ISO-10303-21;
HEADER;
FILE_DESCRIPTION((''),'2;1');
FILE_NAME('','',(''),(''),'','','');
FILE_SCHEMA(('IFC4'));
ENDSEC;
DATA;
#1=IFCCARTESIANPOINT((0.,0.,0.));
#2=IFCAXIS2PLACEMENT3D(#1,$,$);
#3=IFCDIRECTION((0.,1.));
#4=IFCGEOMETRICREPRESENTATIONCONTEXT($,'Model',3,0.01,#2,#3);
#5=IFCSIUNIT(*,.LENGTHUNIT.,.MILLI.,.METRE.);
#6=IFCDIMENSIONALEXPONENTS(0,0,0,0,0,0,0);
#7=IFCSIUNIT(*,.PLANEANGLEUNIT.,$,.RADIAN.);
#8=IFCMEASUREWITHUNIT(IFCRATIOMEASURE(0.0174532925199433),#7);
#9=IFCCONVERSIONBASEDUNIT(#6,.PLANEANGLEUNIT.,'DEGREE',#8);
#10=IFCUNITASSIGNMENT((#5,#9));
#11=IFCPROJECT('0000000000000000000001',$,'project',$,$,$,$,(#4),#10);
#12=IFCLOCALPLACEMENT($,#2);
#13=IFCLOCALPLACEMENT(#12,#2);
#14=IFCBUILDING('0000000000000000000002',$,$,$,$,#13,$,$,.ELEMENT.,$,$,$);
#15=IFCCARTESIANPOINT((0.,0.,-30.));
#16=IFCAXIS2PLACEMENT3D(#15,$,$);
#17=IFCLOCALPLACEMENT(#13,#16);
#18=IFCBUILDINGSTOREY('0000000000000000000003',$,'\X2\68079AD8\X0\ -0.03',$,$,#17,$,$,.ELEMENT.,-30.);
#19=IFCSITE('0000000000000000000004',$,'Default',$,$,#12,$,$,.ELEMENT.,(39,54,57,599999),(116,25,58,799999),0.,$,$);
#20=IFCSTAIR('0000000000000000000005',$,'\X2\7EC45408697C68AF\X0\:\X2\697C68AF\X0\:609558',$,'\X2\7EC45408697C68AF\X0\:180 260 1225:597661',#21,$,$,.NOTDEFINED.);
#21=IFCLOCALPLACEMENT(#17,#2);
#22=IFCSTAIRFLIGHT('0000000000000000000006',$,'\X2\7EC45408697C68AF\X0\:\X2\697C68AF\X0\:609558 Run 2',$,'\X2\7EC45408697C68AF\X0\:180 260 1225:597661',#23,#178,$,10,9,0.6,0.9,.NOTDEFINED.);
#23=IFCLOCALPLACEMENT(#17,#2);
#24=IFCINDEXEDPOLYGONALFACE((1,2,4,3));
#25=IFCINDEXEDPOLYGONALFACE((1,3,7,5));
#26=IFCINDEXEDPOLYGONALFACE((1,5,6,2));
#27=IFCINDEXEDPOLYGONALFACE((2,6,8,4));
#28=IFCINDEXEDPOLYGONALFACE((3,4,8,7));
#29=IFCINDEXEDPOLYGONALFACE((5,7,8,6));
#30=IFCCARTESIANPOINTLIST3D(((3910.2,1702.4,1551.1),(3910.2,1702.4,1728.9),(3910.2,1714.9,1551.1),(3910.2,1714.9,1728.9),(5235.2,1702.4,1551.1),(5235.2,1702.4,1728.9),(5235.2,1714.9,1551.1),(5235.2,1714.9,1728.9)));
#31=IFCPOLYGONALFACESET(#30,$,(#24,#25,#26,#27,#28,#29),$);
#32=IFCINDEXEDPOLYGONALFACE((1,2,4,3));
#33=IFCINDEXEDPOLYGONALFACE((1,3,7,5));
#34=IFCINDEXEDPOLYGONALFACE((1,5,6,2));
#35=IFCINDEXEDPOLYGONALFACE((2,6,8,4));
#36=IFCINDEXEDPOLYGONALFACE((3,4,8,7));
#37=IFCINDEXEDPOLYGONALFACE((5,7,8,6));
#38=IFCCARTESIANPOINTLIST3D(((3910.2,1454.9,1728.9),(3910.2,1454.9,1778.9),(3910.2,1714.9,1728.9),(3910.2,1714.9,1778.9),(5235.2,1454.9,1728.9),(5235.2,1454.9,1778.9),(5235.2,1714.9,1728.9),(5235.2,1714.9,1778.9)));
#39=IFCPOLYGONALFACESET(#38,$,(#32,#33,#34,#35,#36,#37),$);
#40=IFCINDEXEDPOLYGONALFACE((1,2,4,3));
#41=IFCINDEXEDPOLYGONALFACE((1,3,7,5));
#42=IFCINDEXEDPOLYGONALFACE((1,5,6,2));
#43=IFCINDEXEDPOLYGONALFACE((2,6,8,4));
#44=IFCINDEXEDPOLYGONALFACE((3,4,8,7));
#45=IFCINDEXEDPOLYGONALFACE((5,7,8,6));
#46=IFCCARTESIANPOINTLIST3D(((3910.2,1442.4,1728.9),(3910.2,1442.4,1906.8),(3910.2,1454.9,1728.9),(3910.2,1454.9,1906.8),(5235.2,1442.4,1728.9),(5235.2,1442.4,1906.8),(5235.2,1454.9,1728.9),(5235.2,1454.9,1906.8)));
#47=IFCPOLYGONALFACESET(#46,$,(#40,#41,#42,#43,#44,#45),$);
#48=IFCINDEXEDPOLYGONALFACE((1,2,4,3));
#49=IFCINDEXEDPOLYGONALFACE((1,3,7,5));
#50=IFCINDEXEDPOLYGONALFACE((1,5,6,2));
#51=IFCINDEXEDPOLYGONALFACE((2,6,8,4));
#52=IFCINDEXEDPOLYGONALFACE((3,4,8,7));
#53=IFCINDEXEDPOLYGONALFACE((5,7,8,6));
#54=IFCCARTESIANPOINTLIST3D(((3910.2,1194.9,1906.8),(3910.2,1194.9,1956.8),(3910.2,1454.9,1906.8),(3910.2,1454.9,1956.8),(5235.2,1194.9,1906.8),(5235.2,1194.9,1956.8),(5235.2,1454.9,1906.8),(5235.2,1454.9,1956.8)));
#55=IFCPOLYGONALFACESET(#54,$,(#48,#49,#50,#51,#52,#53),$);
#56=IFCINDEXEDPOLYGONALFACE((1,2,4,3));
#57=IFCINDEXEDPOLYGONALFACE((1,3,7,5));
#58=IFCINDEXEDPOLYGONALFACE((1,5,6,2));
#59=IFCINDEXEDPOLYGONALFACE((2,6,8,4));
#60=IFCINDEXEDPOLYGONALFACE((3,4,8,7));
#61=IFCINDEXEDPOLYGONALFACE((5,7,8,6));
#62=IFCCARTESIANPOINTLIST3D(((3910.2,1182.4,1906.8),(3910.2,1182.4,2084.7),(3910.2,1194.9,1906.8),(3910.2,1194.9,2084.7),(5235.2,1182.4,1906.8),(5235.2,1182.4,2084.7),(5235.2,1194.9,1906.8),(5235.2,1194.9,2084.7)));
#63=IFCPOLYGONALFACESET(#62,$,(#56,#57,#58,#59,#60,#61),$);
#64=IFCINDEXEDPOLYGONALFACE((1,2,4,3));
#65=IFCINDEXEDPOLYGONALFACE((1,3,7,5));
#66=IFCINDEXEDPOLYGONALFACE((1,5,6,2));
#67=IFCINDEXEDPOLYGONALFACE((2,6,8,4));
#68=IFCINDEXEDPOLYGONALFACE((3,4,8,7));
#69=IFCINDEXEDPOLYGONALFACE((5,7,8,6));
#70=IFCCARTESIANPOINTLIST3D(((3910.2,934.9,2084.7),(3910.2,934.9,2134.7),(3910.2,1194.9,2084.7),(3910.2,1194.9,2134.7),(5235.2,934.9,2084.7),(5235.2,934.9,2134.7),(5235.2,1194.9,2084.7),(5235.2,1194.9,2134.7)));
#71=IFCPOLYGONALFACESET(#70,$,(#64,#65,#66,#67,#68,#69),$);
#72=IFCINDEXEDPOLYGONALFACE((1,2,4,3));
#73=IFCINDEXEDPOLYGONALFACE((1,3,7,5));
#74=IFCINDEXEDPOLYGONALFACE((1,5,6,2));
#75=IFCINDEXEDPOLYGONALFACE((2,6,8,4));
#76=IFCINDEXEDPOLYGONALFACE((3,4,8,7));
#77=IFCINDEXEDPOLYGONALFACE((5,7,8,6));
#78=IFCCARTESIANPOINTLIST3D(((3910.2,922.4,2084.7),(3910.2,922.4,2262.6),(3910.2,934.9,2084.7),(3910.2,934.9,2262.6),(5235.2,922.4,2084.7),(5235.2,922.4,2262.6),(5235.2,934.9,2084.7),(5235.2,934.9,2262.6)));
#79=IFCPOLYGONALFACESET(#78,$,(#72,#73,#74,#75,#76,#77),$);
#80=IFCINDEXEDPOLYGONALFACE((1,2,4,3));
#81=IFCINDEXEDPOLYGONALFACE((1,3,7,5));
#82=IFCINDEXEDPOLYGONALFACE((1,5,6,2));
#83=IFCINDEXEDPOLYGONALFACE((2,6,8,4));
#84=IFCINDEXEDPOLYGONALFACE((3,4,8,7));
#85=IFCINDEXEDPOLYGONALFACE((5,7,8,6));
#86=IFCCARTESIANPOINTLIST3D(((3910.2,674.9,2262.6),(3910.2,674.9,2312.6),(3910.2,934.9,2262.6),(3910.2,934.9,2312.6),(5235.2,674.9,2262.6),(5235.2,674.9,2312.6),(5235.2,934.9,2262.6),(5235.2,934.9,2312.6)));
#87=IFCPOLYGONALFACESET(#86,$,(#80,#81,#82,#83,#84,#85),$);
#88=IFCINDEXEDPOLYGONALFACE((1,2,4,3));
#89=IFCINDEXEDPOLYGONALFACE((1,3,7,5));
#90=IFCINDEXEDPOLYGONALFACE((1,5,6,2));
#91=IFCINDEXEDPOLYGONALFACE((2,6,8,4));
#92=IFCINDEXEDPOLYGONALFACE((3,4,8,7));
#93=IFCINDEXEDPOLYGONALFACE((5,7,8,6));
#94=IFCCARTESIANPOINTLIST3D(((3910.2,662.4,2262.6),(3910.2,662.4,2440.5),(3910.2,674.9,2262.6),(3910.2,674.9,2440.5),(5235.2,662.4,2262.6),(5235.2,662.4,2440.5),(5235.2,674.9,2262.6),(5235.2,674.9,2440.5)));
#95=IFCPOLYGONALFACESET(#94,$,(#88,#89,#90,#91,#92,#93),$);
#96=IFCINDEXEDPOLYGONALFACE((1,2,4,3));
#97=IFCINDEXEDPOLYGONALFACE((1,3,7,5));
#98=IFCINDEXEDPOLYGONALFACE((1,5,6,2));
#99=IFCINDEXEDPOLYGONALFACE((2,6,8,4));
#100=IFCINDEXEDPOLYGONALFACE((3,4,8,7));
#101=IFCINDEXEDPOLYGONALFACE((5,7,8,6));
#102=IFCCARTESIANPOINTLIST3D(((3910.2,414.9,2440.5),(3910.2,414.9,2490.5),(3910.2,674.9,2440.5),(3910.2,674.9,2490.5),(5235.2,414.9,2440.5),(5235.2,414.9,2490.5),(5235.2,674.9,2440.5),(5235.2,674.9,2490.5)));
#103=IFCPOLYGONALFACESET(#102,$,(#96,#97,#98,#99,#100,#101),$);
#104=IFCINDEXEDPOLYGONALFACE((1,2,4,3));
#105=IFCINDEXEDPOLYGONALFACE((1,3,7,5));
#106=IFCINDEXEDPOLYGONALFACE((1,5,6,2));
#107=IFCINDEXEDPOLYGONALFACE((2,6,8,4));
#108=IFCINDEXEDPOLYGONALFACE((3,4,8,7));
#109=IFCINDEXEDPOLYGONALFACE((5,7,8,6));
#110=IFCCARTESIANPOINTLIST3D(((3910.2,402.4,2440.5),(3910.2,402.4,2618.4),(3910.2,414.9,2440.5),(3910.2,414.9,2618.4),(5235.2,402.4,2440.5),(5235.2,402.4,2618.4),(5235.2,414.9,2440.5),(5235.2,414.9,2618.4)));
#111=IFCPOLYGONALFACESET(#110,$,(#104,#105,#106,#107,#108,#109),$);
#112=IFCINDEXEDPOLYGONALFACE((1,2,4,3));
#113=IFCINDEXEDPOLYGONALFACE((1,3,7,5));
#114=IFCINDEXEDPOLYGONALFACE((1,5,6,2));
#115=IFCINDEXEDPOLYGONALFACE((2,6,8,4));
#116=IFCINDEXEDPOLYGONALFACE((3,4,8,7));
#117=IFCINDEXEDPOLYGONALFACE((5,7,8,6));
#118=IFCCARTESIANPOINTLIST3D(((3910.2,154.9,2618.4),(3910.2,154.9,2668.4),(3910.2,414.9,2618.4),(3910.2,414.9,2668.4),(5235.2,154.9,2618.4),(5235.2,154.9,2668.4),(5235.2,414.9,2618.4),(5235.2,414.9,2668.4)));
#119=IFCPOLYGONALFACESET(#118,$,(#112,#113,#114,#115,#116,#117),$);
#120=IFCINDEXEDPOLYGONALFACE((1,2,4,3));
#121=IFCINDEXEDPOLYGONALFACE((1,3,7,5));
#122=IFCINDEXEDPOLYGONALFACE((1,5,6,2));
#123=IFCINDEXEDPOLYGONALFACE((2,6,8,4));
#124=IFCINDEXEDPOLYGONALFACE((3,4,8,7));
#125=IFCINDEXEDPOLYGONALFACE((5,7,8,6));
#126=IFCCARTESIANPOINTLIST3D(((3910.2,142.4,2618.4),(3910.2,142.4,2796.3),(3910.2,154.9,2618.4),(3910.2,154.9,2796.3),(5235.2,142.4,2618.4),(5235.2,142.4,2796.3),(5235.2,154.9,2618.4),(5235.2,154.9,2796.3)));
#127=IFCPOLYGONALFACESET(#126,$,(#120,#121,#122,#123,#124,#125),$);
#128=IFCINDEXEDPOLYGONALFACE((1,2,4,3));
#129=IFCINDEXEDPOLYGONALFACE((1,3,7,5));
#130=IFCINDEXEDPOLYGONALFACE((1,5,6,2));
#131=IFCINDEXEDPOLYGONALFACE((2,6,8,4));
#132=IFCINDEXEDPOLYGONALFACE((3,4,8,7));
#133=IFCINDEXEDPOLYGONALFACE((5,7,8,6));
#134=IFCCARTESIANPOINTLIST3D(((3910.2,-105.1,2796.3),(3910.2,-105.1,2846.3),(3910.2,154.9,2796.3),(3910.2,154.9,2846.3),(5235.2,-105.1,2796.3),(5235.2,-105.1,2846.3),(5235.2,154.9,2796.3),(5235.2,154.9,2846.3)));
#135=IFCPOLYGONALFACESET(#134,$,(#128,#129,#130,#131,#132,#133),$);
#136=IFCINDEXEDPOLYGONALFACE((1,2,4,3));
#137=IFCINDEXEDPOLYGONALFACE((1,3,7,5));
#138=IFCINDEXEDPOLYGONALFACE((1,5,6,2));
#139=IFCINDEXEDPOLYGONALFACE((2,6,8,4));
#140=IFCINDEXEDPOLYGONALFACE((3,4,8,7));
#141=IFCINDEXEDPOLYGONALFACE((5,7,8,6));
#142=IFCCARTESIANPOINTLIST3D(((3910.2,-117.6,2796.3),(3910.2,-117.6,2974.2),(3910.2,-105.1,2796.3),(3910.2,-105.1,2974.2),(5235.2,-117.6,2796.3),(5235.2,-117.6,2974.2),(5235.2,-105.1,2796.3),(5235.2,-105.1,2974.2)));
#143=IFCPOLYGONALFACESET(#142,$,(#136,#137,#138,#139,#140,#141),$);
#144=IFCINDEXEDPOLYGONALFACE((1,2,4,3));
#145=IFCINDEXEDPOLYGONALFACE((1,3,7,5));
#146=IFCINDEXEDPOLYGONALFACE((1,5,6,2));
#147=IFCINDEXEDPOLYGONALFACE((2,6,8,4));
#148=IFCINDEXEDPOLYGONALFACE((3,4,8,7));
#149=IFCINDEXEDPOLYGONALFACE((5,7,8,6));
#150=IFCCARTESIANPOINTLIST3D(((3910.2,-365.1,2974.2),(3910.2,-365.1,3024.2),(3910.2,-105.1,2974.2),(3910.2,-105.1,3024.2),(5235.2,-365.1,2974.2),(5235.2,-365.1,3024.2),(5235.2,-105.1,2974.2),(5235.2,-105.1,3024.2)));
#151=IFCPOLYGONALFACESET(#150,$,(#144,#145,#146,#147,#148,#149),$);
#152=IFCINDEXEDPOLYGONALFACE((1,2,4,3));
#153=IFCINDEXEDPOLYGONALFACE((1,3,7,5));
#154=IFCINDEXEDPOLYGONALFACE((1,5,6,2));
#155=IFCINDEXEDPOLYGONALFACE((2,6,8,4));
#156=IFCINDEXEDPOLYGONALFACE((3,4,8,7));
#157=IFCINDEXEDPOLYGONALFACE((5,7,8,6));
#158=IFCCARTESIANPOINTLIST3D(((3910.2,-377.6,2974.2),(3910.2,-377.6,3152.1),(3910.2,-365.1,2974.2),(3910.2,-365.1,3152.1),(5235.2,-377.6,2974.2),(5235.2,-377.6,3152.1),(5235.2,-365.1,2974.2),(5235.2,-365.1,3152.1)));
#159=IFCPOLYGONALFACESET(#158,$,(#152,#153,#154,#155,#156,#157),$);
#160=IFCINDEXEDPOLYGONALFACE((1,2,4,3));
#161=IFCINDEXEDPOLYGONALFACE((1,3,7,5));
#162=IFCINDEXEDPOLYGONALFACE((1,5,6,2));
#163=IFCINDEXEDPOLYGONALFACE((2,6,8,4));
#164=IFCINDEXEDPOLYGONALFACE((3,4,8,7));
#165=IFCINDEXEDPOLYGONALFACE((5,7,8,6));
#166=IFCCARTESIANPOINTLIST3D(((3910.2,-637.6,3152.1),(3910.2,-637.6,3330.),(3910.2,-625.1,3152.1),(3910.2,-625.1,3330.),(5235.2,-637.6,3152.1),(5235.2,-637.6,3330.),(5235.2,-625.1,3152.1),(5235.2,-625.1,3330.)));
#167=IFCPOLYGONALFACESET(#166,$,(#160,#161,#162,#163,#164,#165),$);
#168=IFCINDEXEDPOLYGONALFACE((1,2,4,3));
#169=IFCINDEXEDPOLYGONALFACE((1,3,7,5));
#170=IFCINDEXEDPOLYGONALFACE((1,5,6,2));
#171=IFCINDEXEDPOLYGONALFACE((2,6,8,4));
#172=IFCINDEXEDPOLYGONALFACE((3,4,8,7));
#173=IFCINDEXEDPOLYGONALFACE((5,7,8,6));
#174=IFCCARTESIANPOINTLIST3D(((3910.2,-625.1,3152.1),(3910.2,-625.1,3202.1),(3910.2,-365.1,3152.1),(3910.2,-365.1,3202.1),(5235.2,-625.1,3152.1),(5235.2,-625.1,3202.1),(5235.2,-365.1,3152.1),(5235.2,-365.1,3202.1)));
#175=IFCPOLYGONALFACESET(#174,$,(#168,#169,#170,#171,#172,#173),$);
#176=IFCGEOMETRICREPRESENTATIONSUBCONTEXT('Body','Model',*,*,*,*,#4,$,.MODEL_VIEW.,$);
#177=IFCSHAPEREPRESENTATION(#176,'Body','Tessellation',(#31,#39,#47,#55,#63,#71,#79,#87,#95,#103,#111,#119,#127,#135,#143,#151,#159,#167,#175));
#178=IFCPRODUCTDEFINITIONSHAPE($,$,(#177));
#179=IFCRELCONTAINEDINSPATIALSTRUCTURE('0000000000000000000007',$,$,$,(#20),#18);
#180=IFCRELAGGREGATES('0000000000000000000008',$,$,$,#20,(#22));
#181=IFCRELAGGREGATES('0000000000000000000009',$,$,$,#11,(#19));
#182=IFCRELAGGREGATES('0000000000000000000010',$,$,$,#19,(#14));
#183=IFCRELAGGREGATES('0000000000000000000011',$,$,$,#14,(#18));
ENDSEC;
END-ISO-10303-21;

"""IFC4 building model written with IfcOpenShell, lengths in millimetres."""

from ifc_helpers import new_model, entity, si_unit, converted_unit, direction, frame, frame_2d, origin, origin_2d_with_axis, place, context, subcontext, project, spatial, rectangle, extrude, element, aggregate, save


model = new_model("IFC4")

# Units and contexts
model_context = context("Model", 3, precision=0.01, world=origin(), true_north=direction((0.0, 1.0)))
body_context = subcontext(model_context, "Body", "Model", "MODEL_VIEW")
ifc_project = project(units=[si_unit("LENGTHUNIT", "METRE", prefix="MILLI"), converted_unit("PLANEANGLEUNIT", "DEGREE", entity("IfcRatioMeasure", 0.0174532925199433), si_unit("PLANEANGLEUNIT", "RADIAN"), dimensions=[0, 0, 0, 0, 0, 0, 0])], contexts=[model_context])

# Site, building, storey
site_placement = place(None, origin())
site = spatial("IfcSite", under=ifc_project, at=site_placement, Name="Default", CompositionType="ELEMENT", RefLatitude=(39, 54, 57, 599999), RefLongitude=(116, 25, 58, 799999), RefElevation=0.0)
building_placement = place(site_placement, origin())
building = spatial("IfcBuilding", under=site, at=building_placement, CompositionType="ELEMENT")
storey_placement = place(building_placement, frame((0.0, 0.0, -30.0)))
storey = spatial("IfcBuildingStorey", under=building, at=storey_placement, Name="标高 -0.03", CompositionType="ELEMENT", Elevation=-30.0)

# Stair, stair flight
stair_placement = place(storey_placement, origin())
stair = element("IfcStair", 1, at=stair_placement, inside=storey, Name="组合楼梯:楼梯:609558", ObjectType="组合楼梯:180 260 1225:597661", PredefinedType="NOTDEFINED")
stair_flight_1_placement = place(stair_placement, frame((3910.2, -637.6, 0.0)))
stair_flight_1 = element("IfcStairFlight", 2, at=stair_flight_1_placement, Name="组合楼梯:楼梯:609558 Run 2", ObjectType="组合楼梯:180 260 1225:597661", NumberOfRisers=10, NumberOfTreads=9, PredefinedType="NOTDEFINED", RiserHeight=0.6, TreadLength=0.9, context=body_context, shape_type="SweptSolid", body=[
    extrude(rectangle(XDim=1325.0, YDim=12.5, at=frame_2d((0.0, 0.0), x_axis=(1.0, 0.0))), frame((662.5, 2346.2, 1551.1)), (0.0, 0.0, 1.0), 177.9),
    extrude(rectangle(XDim=260.0, YDim=1325.0, at=frame_2d((0.0, 0.0), x_axis=(1.0, 0.0))), frame((662.5, 2222.5, 1728.9), z_axis=(0.0, 0.0, 1.0), x_axis=(0.0, 1.0, 0.0)), (0.0, 0.0, 1.0), 50.0),
    extrude(rectangle(XDim=1325.0, YDim=12.5, at=origin_2d_with_axis()), frame((662.5, 2086.2, 1728.9)), (0.0, 0.0, 1.0), 177.9),
    extrude(rectangle(XDim=260.0, YDim=1325.0, at=frame_2d((0.0, 0.0), x_axis=(1.0, 0.0))), frame((662.5, 1962.5, 1906.8), z_axis=(0.0, 0.0, 1.0), x_axis=(0.0, 1.0, 0.0)), (0.0, 0.0, 1.0), 50.0),
    extrude(rectangle(XDim=1325.0, YDim=12.5, at=origin_2d_with_axis()), frame((662.5, 1826.2, 1906.8)), (0.0, 0.0, 1.0), 177.9),
    extrude(rectangle(XDim=260.0, YDim=1325.0, at=frame_2d((0.0, 0.0), x_axis=(1.0, 0.0))), frame((662.5, 1702.5, 2084.7), z_axis=(0.0, 0.0, 1.0), x_axis=(0.0, 1.0, 0.0)), (0.0, 0.0, 1.0), 50.0),
    extrude(rectangle(XDim=1325.0, YDim=12.5, at=origin_2d_with_axis()), frame((662.5, 1566.2, 2084.7)), (0.0, 0.0, 1.0), 177.9),
    extrude(rectangle(XDim=260.0, YDim=1325.0, at=frame_2d((0.0, 0.0), x_axis=(1.0, 0.0))), frame((662.5, 1442.5, 2262.6), z_axis=(0.0, 0.0, 1.0), x_axis=(0.0, 1.0, 0.0)), (0.0, 0.0, 1.0), 50.0),
    extrude(rectangle(XDim=1325.0, YDim=12.5, at=origin_2d_with_axis()), frame((662.5, 1306.2, 2262.6)), (0.0, 0.0, 1.0), 177.9),
    extrude(rectangle(XDim=260.0, YDim=1325.0, at=frame_2d((0.0, 0.0), x_axis=(1.0, 0.0))), frame((662.5, 1182.5, 2440.5), z_axis=(0.0, 0.0, 1.0), x_axis=(0.0, 1.0, 0.0)), (0.0, 0.0, 1.0), 50.0),
    extrude(rectangle(XDim=1325.0, YDim=12.5, at=origin_2d_with_axis()), frame((662.5, 1046.2, 2440.5)), (0.0, 0.0, 1.0), 177.9),
    extrude(rectangle(XDim=260.0, YDim=1325.0, at=frame_2d((0.0, 0.0), x_axis=(1.0, 0.0))), frame((662.5, 922.5, 2618.4), z_axis=(0.0, 0.0, 1.0), x_axis=(0.0, 1.0, 0.0)), (0.0, 0.0, 1.0), 50.0),
    extrude(rectangle(XDim=1325.0, YDim=12.5, at=origin_2d_with_axis()), frame((662.5, 786.2, 2618.4)), (0.0, 0.0, 1.0), 177.9),
    extrude(rectangle(XDim=260.0, YDim=1325.0, at=frame_2d((0.0, 0.0), x_axis=(1.0, 0.0))), frame((662.5, 662.5, 2796.3), z_axis=(0.0, 0.0, 1.0), x_axis=(0.0, 1.0, 0.0)), (0.0, 0.0, 1.0), 50.0),
    extrude(rectangle(XDim=1325.0, YDim=12.5, at=origin_2d_with_axis()), frame((662.5, 526.2, 2796.3)), (0.0, 0.0, 1.0), 177.9),
    extrude(rectangle(XDim=260.0, YDim=1325.0, at=frame_2d((0.0, 0.0), x_axis=(1.0, 0.0))), frame((662.5, 402.5, 2974.2), z_axis=(0.0, 0.0, 1.0), x_axis=(0.0, 1.0, 0.0)), (0.0, 0.0, 1.0), 50.0),
    extrude(rectangle(XDim=1325.0, YDim=12.5, at=origin_2d_with_axis()), frame((662.5, 266.3, 2974.2)), (0.0, 0.0, 1.0), 177.9),
    extrude(rectangle(XDim=1325.0, YDim=12.5, at=frame_2d((0.0, 0.0), x_axis=(1.0, 0.0))), frame((662.5, 6.2, 3152.1)), (0.0, 0.0, 1.0), 177.9),
    extrude(rectangle(XDim=260.0, YDim=1325.0, at=frame_2d((0.0, 0.0), x_axis=(1.0, 0.0))), frame((662.5, 142.5, 3152.1), z_axis=(0.0, 0.0, 1.0), x_axis=(0.0, 1.0, 0.0)), (0.0, 0.0, 1.0), 50.0),
])
aggregate(stair, [stair_flight_1])

save(model, "model.ifc")
